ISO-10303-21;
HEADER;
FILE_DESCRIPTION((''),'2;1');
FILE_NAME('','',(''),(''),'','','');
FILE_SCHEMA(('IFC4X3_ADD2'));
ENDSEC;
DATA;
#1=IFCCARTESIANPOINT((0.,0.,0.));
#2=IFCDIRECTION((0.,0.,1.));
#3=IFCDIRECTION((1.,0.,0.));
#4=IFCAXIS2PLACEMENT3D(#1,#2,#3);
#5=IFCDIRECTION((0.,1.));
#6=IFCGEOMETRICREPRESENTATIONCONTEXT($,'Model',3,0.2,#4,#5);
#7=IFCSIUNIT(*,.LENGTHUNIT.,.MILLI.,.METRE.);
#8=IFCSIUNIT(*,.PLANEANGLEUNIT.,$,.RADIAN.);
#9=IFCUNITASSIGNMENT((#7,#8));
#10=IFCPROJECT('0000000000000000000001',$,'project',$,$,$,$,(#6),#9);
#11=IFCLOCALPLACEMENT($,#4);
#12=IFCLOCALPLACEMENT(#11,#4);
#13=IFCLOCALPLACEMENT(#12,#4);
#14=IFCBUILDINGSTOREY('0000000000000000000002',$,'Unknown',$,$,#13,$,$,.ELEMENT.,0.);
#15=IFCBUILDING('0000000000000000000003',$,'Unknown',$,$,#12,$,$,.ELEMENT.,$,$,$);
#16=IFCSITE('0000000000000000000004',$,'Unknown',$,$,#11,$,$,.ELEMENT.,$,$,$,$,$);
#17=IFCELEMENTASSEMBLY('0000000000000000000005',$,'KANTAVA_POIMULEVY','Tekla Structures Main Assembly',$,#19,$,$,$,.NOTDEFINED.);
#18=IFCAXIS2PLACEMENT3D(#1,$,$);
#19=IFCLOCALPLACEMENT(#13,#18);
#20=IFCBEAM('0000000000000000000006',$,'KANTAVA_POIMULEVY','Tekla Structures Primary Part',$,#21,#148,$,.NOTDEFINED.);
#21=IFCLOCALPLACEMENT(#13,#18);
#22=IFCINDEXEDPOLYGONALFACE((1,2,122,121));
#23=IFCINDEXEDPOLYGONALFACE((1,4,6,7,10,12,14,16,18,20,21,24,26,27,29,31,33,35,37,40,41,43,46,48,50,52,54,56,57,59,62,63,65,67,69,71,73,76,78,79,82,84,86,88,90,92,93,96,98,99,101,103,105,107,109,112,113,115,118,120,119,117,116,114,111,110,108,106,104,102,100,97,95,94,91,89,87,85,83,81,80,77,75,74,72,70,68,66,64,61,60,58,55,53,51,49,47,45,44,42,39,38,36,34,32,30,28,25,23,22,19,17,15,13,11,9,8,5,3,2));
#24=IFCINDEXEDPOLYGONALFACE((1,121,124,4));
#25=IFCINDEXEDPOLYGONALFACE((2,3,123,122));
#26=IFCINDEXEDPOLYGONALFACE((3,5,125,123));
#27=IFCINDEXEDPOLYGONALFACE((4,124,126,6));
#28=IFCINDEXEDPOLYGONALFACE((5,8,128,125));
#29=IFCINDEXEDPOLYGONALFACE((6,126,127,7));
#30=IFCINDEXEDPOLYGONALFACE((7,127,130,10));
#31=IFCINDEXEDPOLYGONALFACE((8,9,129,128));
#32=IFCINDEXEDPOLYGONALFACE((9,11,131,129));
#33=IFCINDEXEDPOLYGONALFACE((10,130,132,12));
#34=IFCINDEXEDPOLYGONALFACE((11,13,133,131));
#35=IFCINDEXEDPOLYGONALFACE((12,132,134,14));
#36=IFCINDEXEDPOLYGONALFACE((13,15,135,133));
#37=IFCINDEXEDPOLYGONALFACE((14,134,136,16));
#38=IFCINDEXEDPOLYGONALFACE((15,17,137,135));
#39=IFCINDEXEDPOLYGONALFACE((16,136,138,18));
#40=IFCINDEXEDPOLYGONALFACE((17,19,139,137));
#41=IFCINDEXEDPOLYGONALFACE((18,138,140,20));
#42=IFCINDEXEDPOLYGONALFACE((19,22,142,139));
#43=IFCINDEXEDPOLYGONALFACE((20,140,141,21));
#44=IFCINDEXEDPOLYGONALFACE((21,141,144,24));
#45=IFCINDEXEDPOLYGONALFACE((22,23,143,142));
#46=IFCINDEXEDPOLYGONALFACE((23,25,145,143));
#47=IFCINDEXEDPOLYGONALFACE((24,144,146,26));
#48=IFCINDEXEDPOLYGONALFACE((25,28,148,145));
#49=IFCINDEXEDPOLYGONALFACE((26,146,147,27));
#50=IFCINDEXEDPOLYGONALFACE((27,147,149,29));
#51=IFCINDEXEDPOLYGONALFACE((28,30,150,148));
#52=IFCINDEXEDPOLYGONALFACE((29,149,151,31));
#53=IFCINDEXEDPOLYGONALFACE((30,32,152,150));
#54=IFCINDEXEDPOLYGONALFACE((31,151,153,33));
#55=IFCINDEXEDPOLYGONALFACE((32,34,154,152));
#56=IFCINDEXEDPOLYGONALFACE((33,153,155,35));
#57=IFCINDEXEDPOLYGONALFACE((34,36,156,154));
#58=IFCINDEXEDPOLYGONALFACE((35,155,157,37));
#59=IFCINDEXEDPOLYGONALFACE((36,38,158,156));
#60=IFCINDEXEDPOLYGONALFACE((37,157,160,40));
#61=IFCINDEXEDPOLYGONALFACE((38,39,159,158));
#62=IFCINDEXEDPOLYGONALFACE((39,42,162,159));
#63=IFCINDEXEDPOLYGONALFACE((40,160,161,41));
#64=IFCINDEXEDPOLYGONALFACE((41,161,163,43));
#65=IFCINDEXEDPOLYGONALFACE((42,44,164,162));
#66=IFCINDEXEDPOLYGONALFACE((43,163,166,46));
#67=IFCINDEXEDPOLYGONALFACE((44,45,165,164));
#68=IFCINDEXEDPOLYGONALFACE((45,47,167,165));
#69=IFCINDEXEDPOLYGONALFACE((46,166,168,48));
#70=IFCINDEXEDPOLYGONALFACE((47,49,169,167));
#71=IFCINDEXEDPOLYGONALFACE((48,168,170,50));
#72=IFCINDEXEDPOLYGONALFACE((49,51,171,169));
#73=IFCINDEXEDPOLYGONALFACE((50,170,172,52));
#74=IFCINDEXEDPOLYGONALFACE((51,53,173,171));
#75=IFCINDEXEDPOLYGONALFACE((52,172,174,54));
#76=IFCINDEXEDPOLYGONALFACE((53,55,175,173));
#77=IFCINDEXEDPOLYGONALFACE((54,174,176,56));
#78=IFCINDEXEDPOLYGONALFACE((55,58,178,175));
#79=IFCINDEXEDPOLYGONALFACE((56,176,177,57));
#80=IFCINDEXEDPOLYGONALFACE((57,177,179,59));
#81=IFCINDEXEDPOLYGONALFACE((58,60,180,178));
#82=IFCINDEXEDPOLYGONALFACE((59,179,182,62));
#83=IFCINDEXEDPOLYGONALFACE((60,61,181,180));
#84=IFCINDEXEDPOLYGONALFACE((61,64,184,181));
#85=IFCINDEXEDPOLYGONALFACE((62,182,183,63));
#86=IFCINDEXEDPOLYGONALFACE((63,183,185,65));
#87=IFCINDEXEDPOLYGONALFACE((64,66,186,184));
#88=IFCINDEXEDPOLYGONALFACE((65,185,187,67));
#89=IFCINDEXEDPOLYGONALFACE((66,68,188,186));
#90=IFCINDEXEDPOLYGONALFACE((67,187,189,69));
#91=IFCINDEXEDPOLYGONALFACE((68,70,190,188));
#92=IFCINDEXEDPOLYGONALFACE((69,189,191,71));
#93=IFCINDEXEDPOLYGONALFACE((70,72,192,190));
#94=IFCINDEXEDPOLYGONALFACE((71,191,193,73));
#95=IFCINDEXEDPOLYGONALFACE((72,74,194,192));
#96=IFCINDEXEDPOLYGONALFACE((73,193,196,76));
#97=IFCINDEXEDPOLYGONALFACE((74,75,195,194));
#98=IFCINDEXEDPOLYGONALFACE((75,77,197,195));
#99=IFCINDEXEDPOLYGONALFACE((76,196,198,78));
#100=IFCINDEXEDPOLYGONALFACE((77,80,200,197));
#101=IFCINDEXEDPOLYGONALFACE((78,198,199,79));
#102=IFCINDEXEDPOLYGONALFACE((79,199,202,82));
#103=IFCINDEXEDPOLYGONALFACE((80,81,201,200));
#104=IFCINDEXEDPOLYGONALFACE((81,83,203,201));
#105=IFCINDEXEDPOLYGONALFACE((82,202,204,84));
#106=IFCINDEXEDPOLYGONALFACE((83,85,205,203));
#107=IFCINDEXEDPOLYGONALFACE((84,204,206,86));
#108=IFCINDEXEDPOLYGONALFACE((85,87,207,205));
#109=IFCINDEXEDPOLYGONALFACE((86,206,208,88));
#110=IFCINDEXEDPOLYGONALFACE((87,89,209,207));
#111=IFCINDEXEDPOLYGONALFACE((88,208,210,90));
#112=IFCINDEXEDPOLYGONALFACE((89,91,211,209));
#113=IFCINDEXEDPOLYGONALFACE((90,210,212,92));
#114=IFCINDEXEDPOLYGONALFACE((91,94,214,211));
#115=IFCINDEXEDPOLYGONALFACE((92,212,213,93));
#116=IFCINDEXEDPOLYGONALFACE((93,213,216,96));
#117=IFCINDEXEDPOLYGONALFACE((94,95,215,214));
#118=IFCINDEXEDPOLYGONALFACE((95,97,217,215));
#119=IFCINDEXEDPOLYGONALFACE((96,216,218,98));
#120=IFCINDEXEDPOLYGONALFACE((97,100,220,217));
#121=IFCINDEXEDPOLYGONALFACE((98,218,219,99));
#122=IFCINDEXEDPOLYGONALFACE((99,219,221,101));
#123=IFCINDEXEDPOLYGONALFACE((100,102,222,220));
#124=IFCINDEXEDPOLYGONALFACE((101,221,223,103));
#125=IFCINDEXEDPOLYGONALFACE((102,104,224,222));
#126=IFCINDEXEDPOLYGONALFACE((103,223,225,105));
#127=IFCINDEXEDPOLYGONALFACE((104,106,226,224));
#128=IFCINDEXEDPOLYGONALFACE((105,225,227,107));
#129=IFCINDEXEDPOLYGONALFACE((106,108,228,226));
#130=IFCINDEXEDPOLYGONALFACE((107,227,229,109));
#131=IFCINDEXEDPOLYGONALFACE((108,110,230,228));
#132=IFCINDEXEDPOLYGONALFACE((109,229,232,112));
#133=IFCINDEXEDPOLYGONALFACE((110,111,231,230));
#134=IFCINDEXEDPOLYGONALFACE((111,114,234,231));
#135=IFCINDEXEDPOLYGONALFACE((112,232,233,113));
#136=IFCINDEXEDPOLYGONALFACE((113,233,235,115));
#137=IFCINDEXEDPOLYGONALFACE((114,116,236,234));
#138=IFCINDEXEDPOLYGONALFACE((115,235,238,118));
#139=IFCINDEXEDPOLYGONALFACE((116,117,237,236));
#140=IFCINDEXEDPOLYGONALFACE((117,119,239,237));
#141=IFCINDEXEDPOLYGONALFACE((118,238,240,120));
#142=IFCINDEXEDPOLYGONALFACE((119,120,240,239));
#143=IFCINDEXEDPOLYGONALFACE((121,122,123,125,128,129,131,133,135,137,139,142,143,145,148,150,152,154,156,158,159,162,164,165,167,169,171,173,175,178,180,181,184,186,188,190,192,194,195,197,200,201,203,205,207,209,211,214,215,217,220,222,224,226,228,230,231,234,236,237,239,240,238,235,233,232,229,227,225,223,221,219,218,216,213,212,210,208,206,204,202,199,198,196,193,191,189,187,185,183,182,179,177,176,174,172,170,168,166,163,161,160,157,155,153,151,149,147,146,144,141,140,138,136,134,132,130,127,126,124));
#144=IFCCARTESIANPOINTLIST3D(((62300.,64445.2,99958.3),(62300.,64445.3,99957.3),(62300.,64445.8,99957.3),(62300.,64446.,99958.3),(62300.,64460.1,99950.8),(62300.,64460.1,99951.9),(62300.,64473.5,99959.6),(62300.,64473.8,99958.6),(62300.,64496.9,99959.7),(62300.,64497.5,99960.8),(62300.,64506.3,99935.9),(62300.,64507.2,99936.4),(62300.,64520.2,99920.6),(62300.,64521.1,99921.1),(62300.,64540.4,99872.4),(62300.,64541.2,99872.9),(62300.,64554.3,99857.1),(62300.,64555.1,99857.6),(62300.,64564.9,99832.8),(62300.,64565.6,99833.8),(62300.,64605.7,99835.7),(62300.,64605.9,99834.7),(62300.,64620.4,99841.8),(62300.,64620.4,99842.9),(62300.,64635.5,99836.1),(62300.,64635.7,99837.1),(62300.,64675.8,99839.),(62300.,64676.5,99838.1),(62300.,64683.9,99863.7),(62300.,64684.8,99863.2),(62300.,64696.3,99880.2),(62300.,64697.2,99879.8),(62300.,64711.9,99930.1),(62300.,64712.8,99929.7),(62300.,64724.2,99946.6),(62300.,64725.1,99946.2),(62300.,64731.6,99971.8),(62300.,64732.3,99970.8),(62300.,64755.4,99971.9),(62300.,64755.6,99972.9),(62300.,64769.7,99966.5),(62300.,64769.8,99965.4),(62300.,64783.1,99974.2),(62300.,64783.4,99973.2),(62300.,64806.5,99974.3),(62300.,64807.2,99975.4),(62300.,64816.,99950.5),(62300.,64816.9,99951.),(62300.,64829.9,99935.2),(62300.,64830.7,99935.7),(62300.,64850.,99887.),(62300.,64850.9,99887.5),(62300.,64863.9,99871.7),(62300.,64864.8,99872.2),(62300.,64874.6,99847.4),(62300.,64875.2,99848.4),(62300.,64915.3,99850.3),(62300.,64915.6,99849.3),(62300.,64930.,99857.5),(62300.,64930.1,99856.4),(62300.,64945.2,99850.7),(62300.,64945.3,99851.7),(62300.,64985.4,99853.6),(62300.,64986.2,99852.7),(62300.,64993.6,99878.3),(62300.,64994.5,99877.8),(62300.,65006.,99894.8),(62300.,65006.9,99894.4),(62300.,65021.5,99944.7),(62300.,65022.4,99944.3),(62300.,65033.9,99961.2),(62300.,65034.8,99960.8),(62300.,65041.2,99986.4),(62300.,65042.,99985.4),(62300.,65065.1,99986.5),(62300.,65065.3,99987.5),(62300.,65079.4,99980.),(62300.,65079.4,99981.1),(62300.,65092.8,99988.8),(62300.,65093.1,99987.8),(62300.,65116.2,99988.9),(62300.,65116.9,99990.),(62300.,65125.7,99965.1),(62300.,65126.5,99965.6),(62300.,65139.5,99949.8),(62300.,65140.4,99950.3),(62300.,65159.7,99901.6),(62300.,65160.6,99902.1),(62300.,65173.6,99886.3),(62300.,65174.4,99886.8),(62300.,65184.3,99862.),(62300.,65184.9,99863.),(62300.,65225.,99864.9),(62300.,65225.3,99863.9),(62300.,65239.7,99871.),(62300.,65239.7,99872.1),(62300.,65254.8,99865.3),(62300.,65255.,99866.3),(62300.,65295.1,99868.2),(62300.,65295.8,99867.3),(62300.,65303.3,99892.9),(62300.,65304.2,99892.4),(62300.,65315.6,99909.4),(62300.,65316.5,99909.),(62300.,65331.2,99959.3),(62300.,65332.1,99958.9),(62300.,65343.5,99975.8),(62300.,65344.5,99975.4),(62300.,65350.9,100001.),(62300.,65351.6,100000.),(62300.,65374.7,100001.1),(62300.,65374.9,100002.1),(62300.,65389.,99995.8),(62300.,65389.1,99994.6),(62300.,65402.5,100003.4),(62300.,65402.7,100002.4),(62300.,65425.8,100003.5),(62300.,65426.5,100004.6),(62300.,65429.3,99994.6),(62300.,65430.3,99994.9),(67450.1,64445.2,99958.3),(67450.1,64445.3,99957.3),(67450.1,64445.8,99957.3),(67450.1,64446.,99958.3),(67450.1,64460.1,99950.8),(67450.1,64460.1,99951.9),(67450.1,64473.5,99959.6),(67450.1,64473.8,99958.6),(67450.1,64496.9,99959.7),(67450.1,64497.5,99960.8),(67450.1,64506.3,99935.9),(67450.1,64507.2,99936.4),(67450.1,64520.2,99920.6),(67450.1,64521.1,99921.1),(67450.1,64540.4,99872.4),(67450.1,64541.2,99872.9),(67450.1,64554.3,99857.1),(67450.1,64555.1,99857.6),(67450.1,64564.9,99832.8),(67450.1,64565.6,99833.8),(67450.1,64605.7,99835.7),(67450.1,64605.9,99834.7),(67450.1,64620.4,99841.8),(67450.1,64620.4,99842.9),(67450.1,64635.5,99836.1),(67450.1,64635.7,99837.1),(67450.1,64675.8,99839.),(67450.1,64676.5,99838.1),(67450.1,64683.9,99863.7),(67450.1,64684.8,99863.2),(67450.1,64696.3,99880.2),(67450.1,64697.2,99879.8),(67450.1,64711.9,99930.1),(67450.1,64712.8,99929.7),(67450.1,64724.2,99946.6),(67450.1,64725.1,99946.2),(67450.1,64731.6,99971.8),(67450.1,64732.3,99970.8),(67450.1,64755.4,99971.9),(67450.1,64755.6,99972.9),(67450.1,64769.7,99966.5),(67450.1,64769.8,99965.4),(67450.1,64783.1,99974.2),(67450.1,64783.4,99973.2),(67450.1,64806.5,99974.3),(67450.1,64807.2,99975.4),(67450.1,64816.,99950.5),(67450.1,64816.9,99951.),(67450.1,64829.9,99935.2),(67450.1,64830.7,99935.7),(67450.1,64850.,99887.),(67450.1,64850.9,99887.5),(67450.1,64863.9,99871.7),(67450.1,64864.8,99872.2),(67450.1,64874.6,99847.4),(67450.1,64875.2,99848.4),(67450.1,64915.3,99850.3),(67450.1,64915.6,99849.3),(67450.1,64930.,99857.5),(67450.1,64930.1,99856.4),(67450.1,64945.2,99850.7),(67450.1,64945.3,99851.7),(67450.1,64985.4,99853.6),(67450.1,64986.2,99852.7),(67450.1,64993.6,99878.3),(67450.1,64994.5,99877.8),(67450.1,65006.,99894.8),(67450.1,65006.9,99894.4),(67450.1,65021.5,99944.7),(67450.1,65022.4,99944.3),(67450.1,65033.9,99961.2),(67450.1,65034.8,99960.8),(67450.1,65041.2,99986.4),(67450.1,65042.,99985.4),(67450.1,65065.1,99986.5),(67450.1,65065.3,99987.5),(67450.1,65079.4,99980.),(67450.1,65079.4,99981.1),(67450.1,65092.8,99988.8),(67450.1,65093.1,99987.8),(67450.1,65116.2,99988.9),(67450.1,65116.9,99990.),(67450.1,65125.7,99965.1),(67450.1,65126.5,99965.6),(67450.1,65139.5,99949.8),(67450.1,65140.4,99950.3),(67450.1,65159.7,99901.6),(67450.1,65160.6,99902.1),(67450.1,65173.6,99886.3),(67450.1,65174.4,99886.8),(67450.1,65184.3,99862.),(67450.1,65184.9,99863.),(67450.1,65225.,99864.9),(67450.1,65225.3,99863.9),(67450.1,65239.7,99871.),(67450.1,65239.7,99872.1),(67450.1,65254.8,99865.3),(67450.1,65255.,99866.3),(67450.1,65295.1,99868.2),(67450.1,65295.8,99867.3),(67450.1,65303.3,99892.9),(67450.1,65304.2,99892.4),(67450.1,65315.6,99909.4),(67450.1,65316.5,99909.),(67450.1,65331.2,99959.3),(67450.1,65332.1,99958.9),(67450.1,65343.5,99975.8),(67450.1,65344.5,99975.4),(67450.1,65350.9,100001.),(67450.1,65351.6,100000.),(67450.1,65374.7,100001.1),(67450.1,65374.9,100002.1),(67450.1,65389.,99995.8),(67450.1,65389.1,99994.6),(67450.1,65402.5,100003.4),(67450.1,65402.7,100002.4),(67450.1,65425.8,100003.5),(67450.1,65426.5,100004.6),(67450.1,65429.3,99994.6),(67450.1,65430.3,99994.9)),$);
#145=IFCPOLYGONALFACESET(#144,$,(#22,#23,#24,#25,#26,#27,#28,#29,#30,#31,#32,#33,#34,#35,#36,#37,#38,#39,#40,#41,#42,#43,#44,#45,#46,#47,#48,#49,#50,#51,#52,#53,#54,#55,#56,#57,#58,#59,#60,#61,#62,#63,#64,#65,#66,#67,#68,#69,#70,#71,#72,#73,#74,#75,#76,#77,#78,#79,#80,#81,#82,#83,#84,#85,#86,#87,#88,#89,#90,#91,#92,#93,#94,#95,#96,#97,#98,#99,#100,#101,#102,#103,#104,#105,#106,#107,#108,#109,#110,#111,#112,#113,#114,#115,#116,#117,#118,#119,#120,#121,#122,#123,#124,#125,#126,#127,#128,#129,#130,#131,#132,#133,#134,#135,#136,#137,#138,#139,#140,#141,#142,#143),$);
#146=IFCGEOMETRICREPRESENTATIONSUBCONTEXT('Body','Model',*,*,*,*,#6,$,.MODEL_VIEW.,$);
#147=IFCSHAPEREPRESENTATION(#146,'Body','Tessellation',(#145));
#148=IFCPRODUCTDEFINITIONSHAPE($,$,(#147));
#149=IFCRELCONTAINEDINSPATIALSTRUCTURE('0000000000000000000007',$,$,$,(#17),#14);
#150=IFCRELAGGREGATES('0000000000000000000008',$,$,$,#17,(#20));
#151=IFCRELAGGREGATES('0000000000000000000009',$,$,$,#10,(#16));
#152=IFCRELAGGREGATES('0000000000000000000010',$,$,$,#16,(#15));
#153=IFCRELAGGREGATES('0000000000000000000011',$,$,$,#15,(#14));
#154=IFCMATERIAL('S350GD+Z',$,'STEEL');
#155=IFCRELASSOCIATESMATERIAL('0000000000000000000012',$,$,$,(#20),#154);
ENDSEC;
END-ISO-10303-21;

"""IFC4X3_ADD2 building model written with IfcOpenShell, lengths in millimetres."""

from ifc_helpers import new_model, si_unit, direction, frame, origin_with_axes, place, context, subcontext, project, spatial, line, indexed_curve, outline, extrude, material, element, aggregate, save


model = new_model("IFC4X3_ADD2")

# Units and contexts
model_context = context("Model", 3, precision=0.2, world=origin_with_axes(), true_north=direction((0.0, 1.0)))
body_context = subcontext(model_context, "Body", "Model", "MODEL_VIEW")
ifc_project = project(units=[si_unit("LENGTHUNIT", "METRE", prefix="MILLI"), si_unit("PLANEANGLEUNIT", "RADIAN")], contexts=[model_context])

# Site, building, storey
site_placement = place(None, origin_with_axes())
site = spatial("IfcSite", under=ifc_project, at=site_placement, Name="Unknown", CompositionType="ELEMENT")
building_placement = place(site_placement, origin_with_axes())
building = spatial("IfcBuilding", under=site, at=building_placement, Name="Unknown", CompositionType="ELEMENT")
storey_placement = place(building_placement, origin_with_axes())
storey = spatial("IfcBuildingStorey", under=building, at=storey_placement, Name="Unknown", CompositionType="ELEMENT", Elevation=0.0)

# Element assembly, beam
ifc_material_1 = material(Name="S350GD+Z", Category="STEEL")
assembly_1_placement = place(storey_placement, frame((62300.0, 64927.3, 99915.5), z_axis=(0.0, -0.99889, -0.047106), x_axis=(1.0, 0.0, 0.0)))
assembly_1 = element("IfcElementAssembly", 1, at=assembly_1_placement, inside=storey, Name="KANTAVA_POIMULEVY", Description="Tekla Structures Main Assembly", PredefinedType="NOTDEFINED")
beam_1_placement = place(assembly_1_placement, origin_with_axes())
beam_1 = element("IfcBeam", 2, at=beam_1_placement, material=ifc_material_1, Name="KANTAVA_POIMULEVY", Description="Tekla Structures Primary Part", PredefinedType="NOTDEFINED", context=body_context, shape_type="SolidModel", body=[
    extrude(outline(indexed_curve([(479.5, 65.5), (478.8, 65.5), (465.0, 58.5), (451.2, 65.5), (427.1, 65.5), (418.6, 40.7), (405.5, 24.8), (387.6, -24.3), (374.5, -40.2), (365.1, -64.5), (325.0, -64.5), (310.0, -58.1), (295.0, -64.5), (254.8, -64.5), (245.5, -40.2), (232.4, -24.3), (214.5, 24.8), (201.4, 40.7), (192.9, 65.5), (168.8, 65.5), (155.0, 58.5), (141.2, 65.5), (117.1, 65.5), (108.6, 40.7), (95.5, 24.8), (77.6, -24.3), (64.5, -40.2), (55.1, -64.5), (15.0, -64.5), (0.0, -58.1), (-15.0, -64.5), (-55.2, -64.5), (-64.5, -40.2), (-77.6, -24.3), (-95.5, 24.8), (-108.6, 40.7), (-117.2, 65.5), (-141.2, 65.5), (-155.0, 58.5), (-168.8, 65.5), (-192.9, 65.5), (-201.4, 40.7), (-214.5, 24.8), (-232.4, -24.3), (-245.5, -40.2), (-254.9, -64.5), (-295.0, -64.5), (-310.0, -58.1), (-325.0, -64.5), (-365.2, -64.5), (-374.5, -40.2), (-387.6, -24.3), (-405.5, 24.8), (-418.6, 40.7), (-427.1, 65.5), (-451.2, 65.5), (-465.0, 58.5), (-478.8, 65.5), (-502.9, 65.5), (-506.2, 55.7), (-505.2, 55.4), (-502.1, 64.5), (-479.0, 64.5), (-465.0, 57.3), (-451.0, 64.5), (-427.9, 64.5), (-419.5, 40.2), (-406.4, 24.3), (-388.5, -24.8), (-375.4, -40.7), (-365.9, -65.5), (-324.8, -65.5), (-310.0, -59.1), (-295.2, -65.5), (-254.2, -65.5), (-244.6, -40.7), (-231.5, -24.8), (-213.6, 24.3), (-200.5, 40.2), (-192.1, 64.5), (-169.0, 64.5), (-155.0, 57.3), (-141.0, 64.5), (-117.9, 64.5), (-109.5, 40.2), (-96.4, 24.3), (-78.5, -24.8), (-65.4, -40.7), (-55.9, -65.5), (-14.8, -65.5), (0.0, -59.1), (14.8, -65.5), (55.8, -65.5), (65.4, -40.7), (78.5, -24.8), (96.4, 24.3), (109.5, 40.2), (117.8, 64.5), (141.0, 64.5), (155.0, 57.3), (169.0, 64.5), (192.1, 64.5), (200.5, 40.2), (213.6, 24.3), (231.5, -24.8), (244.6, -40.7), (254.1, -65.5), (295.2, -65.5), (310.0, -59.1), (324.8, -65.5), (365.8, -65.5), (375.4, -40.7), (388.5, -24.8), (406.4, 24.3), (419.5, 40.2), (427.9, 64.5), (451.0, 64.5), (465.0, 57.3), (479.0, 64.5), (479.5, 64.5)], segments=[line(1, 2, 3, 4, 5, 6, 7, 8, 9, 10, 11, 12, 13, 14, 15, 16, 17, 18, 19, 20, 21, 22, 23, 24, 25, 26, 27, 28, 29, 30, 31, 32, 33, 34, 35, 36, 37, 38, 39, 40, 41, 42, 43, 44, 45, 46, 47, 48, 49, 50, 51, 52, 53, 54, 55, 56, 57, 58, 59, 60, 61, 62, 63, 64, 65, 66, 67, 68, 69, 70, 71, 72, 73, 74, 75, 76, 77, 78, 79, 80, 81, 82, 83, 84, 85, 86, 87, 88, 89, 90, 91, 92, 93, 94, 95, 96, 97, 98, 99, 100, 101, 102, 103, 104, 105, 106, 107, 108, 109, 110, 111, 112, 113, 114, 115, 116, 117, 118, 119, 120, 1)])), frame((0.0, 0.0, 0.0), z_axis=(-1.0, 0.0, 0.0), x_axis=(0.0, 0.0, 1.0)), (0.0, 0.0, -1.0), 5150.1),
])
aggregate(assembly_1, [beam_1])

save(model, "model.ifc")
